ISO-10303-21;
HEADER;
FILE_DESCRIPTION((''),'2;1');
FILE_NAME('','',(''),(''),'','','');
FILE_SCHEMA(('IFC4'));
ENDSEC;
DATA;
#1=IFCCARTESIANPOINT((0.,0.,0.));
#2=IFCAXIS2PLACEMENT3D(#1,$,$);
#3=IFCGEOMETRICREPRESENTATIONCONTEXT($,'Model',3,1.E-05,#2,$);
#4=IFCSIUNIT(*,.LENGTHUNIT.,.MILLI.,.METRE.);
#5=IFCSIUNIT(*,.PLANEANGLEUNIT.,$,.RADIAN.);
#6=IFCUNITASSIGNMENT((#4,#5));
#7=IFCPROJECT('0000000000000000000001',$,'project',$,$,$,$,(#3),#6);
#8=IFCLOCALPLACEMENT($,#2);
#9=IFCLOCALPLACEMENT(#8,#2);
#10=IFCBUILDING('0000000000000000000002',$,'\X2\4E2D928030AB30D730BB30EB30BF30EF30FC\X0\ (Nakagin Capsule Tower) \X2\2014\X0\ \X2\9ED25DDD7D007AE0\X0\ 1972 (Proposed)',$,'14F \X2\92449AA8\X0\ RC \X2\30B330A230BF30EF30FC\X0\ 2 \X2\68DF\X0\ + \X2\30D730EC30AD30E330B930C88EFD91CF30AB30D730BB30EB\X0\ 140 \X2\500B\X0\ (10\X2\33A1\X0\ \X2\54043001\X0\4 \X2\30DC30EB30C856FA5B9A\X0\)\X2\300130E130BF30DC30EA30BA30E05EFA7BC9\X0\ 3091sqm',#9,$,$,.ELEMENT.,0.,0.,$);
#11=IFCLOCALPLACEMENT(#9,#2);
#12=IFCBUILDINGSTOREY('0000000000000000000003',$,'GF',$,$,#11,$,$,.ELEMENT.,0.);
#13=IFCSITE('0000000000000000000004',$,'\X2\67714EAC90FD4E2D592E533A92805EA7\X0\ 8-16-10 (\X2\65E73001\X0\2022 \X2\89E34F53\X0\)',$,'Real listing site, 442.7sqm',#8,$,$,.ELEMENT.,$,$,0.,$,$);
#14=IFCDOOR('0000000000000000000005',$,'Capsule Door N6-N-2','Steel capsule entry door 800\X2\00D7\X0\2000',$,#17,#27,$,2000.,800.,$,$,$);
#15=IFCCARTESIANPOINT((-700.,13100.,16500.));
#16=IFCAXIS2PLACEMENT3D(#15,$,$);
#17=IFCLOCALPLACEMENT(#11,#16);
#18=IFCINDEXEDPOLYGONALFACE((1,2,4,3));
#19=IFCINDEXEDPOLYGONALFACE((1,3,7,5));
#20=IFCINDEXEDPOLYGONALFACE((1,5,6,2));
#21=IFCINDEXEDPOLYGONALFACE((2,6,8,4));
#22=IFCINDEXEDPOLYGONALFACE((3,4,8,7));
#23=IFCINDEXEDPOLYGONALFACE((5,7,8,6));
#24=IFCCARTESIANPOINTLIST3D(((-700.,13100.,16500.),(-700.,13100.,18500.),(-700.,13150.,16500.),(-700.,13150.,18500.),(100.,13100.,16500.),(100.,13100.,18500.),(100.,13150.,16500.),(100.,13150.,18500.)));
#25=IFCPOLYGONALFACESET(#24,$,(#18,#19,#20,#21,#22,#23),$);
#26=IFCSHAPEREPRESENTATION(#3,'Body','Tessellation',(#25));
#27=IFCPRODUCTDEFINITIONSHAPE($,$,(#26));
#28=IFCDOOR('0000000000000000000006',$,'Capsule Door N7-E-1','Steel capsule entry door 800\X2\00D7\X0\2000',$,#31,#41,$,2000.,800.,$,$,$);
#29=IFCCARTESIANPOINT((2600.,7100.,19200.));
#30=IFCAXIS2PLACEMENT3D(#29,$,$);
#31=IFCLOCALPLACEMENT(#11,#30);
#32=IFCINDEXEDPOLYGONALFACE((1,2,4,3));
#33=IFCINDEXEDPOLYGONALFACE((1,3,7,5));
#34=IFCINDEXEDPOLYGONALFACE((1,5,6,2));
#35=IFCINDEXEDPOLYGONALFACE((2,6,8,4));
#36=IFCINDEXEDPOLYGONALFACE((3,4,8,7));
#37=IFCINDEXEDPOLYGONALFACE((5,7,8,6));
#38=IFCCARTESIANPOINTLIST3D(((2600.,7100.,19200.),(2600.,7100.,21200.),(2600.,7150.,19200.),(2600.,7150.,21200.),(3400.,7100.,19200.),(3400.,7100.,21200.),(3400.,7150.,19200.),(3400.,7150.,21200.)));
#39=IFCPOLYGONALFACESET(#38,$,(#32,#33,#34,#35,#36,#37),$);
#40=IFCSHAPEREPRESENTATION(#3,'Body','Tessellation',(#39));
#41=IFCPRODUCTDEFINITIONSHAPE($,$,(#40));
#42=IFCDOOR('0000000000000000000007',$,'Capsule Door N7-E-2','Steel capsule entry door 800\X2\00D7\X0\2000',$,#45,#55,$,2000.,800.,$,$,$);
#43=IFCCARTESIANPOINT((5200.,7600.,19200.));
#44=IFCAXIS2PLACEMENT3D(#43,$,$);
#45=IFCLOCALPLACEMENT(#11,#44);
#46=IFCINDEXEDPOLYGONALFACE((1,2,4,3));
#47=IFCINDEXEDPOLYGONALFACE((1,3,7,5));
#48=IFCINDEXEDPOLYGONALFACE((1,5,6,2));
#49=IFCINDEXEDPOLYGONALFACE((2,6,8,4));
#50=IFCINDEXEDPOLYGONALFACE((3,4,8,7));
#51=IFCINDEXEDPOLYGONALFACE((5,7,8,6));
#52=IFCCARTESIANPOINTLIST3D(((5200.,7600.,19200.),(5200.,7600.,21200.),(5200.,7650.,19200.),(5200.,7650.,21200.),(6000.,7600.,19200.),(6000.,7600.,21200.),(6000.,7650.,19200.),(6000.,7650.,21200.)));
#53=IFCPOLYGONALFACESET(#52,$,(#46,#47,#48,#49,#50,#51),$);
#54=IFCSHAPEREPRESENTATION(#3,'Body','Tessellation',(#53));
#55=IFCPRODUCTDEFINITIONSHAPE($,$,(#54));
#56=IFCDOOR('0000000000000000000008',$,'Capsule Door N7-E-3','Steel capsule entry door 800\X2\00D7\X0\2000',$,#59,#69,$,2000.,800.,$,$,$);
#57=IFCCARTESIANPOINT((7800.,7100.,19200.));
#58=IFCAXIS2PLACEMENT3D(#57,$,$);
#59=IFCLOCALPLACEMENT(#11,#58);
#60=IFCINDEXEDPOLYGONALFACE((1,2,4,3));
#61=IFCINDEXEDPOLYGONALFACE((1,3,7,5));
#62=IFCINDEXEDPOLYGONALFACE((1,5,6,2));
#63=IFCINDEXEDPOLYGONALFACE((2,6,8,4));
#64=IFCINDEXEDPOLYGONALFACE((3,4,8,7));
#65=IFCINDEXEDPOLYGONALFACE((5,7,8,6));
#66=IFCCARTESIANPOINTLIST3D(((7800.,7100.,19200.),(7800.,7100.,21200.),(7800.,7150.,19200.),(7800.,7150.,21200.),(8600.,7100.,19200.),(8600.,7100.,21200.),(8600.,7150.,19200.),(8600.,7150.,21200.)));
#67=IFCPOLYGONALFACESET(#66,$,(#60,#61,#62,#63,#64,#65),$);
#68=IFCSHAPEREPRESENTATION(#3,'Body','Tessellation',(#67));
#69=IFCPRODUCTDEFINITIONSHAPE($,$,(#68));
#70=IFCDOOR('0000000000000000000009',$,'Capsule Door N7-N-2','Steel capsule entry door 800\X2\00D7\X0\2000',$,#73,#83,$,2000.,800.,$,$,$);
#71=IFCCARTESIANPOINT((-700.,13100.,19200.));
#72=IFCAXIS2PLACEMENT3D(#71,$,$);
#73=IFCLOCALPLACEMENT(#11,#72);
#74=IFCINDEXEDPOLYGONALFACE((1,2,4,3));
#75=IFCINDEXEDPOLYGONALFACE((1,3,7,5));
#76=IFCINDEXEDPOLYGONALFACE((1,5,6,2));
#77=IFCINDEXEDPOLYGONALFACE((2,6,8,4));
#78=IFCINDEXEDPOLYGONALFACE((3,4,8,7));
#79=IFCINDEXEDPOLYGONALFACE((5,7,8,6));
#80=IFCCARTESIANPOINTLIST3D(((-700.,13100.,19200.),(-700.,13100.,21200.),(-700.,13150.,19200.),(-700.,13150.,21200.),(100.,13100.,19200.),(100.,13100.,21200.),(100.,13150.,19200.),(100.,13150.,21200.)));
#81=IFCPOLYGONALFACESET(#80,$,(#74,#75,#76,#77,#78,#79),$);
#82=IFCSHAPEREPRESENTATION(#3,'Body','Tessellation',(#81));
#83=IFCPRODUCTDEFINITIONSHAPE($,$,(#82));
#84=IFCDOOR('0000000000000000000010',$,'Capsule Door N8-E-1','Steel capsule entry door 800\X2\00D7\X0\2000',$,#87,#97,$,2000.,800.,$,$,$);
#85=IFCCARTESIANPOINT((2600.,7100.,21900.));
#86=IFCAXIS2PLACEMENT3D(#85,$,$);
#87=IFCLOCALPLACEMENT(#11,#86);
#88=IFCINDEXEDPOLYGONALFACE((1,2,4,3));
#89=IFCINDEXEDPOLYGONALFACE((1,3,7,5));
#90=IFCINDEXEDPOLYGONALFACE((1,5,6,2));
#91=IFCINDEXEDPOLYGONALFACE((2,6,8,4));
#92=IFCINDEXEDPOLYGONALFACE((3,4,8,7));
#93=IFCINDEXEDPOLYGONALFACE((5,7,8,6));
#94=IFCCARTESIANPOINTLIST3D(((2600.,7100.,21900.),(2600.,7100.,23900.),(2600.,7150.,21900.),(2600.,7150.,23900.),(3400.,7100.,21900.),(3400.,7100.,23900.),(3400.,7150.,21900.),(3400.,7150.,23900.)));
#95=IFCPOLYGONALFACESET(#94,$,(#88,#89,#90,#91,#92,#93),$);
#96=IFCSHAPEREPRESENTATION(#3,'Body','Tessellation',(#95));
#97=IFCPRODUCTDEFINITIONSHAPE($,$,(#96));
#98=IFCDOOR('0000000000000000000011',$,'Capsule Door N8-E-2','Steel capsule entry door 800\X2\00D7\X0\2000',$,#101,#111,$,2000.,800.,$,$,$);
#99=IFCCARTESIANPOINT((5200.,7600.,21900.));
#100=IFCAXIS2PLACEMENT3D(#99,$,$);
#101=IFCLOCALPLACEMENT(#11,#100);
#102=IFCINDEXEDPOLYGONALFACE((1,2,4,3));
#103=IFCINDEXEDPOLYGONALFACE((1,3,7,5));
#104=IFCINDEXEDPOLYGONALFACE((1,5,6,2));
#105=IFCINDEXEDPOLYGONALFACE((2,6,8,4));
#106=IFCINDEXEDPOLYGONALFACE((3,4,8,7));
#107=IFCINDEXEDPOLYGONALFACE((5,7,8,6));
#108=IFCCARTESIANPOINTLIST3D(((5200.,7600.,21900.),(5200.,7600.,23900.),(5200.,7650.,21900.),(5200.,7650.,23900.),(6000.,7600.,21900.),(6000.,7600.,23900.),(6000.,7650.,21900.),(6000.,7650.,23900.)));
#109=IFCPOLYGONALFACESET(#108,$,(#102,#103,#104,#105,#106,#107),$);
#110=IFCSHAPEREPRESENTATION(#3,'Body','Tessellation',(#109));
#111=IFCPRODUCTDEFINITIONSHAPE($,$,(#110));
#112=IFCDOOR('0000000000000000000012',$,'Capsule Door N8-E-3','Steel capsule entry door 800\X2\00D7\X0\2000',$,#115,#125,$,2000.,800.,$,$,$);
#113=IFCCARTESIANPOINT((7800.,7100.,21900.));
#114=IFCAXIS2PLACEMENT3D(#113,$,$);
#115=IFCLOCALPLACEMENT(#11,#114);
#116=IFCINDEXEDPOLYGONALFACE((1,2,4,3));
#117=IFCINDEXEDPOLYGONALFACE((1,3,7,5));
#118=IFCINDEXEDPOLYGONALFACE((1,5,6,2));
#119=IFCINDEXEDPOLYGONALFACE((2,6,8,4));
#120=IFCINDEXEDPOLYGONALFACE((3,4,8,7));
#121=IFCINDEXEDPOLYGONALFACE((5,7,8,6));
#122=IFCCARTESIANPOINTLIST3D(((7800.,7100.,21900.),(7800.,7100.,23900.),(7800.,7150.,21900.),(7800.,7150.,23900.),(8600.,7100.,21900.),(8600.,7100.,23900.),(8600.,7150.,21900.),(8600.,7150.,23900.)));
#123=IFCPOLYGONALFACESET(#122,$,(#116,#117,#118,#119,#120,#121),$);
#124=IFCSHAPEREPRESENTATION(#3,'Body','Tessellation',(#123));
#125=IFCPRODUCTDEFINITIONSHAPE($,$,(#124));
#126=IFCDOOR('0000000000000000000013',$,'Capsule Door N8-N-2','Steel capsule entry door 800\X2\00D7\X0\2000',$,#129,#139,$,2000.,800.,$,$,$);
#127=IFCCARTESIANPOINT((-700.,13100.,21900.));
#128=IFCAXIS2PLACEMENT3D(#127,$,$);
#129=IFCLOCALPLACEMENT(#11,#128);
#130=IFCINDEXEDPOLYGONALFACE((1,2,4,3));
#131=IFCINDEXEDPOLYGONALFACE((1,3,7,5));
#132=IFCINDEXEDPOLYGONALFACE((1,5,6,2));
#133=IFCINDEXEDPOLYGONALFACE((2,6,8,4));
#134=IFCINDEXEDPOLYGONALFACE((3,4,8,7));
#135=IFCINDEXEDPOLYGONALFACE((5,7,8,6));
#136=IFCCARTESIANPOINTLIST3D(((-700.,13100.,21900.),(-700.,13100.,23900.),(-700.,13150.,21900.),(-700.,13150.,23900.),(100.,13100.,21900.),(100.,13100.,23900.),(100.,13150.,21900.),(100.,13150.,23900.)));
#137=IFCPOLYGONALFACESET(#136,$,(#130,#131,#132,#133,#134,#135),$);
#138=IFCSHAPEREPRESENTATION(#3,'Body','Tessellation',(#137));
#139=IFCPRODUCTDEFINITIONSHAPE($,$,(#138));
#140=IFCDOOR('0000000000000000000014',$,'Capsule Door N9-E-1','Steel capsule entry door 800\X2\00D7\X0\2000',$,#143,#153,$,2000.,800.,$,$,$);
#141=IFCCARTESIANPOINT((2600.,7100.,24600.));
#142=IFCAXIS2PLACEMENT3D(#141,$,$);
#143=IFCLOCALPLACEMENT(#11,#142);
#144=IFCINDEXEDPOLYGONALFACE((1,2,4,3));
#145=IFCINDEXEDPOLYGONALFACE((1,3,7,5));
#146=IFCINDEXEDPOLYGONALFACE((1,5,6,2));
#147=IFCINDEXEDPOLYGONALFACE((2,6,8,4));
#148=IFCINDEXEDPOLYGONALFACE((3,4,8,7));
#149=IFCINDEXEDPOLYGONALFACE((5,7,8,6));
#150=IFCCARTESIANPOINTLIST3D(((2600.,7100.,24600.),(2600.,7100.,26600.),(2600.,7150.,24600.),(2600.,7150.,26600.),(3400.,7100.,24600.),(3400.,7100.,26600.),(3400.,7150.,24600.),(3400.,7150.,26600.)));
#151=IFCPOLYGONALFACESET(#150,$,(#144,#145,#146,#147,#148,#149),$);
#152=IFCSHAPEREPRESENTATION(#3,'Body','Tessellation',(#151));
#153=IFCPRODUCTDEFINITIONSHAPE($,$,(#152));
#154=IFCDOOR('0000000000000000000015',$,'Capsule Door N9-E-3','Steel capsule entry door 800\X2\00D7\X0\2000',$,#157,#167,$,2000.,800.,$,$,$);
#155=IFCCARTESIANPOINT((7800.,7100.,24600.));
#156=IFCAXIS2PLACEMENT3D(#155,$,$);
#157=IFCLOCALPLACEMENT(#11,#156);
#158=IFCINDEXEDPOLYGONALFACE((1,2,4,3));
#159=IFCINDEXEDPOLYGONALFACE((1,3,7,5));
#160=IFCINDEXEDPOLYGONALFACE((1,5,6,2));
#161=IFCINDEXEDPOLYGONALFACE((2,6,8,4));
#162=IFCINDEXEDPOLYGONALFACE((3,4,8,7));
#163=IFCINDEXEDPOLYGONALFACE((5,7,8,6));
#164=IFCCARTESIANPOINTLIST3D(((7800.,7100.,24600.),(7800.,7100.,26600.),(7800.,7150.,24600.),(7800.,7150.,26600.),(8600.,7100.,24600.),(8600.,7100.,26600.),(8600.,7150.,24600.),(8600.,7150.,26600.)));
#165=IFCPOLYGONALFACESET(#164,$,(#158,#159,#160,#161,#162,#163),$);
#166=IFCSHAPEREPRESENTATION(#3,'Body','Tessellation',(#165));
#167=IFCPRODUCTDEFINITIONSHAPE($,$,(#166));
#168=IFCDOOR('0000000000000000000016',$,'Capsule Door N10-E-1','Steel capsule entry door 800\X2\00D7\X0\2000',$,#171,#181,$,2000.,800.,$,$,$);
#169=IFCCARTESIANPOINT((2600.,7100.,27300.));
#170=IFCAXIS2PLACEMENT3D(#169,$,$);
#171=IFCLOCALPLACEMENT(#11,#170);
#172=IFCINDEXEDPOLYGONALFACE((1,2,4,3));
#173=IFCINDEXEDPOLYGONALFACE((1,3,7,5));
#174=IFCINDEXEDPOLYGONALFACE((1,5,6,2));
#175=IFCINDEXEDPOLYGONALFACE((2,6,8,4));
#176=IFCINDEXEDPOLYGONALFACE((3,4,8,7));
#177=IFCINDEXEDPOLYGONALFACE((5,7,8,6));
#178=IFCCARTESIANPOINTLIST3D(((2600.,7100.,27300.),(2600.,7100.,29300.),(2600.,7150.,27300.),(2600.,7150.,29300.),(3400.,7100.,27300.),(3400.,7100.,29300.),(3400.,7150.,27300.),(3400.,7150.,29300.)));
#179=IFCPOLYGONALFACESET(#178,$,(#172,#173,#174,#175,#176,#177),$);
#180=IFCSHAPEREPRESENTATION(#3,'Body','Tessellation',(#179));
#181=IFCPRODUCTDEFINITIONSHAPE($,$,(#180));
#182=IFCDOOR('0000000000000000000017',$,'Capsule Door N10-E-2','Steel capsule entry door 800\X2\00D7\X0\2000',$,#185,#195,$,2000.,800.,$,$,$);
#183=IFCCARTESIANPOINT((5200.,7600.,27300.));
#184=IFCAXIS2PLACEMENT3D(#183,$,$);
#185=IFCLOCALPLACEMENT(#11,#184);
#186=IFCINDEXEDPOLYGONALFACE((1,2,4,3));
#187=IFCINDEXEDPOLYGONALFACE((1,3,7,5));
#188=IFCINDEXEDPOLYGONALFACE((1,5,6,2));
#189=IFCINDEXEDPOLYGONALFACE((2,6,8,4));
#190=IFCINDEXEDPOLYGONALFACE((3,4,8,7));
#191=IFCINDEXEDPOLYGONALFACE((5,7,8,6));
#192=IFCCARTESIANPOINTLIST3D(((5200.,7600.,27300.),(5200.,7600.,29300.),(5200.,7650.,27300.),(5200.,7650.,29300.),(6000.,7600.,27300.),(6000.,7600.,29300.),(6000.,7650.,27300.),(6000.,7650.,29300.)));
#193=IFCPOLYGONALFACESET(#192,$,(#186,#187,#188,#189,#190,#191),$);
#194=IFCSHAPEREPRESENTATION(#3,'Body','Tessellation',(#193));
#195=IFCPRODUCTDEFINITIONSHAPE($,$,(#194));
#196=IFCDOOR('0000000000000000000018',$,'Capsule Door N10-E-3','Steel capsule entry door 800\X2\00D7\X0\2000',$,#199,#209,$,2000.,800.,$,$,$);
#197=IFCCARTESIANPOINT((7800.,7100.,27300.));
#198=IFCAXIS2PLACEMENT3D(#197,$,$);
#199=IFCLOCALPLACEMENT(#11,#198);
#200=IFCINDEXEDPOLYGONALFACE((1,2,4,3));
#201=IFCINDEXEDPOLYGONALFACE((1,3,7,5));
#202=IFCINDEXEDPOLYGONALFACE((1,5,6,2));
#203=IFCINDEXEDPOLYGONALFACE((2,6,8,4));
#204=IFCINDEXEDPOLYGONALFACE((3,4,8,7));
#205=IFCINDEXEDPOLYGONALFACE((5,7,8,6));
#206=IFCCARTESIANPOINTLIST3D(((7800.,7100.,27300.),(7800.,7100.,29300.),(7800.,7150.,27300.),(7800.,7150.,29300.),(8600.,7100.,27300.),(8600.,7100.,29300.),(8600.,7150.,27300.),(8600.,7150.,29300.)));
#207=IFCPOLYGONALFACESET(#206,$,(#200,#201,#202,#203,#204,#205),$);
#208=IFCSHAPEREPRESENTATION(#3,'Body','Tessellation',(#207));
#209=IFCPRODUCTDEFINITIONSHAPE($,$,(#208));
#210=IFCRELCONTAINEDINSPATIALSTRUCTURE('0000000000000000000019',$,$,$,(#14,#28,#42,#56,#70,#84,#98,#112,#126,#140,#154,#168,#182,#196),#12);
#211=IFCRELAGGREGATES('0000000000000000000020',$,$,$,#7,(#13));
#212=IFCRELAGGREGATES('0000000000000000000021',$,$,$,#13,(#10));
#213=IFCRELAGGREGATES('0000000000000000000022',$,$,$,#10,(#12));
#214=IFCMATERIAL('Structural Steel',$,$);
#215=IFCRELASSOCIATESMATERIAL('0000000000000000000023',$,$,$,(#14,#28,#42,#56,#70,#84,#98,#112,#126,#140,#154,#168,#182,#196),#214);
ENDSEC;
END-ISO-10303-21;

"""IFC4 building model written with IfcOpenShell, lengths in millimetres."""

from ifc_helpers import new_model, si_unit, frame, frame_2d, origin, place, context, project, spatial, rectangle, extrude, material, element, save


model = new_model("IFC4")

# Units and contexts
model_context = context("Model", 3, precision=1e-05, world=origin())
ifc_project = project(units=[si_unit("LENGTHUNIT", "METRE", prefix="MILLI"), si_unit("PLANEANGLEUNIT", "RADIAN")], contexts=[model_context])

# Site, building, storey
site_placement = place(None, origin())
site = spatial("IfcSite", under=ifc_project, at=site_placement, Name="東京都中央区銀座 8-16-10 (旧、2022 解体)", ObjectType="Real listing site, 442.7sqm", CompositionType="ELEMENT", RefElevation=0.0)
building_placement = place(site_placement, origin())
building = spatial("IfcBuilding", under=site, at=building_placement, Name="中銀カプセルタワー (Nakagin Capsule Tower) — 黒川紀章 1972 (Proposed)", ObjectType="14F 鉄骨 RC コアタワー 2 棟 + プレキャスト軽量カプセル 140 個 (10㎡ 各、4 ボルト固定)、メタボリズム建築 3091sqm", CompositionType="ELEMENT", ElevationOfRefHeight=0.0, ElevationOfTerrain=0.0)
storey_placement = place(building_placement, origin())
storey = spatial("IfcBuildingStorey", under=building, at=storey_placement, Name="GF", CompositionType="ELEMENT", Elevation=0.0)

# Doors
ifc_material_1 = material(Name="Structural Steel")
door_1_placement = place(storey_placement, frame((-700.0, 13100.0, 16500.0)))
element("IfcDoor", 1, at=door_1_placement, inside=storey, material=ifc_material_1, Name="Capsule Door N6-N-2", Description="Steel capsule entry door 800×2000", OverallHeight=2000.0, OverallWidth=800.0, context=model_context, shape_type="SweptSolid", body=[
    extrude(rectangle(XDim=800.0, YDim=50.0, at=frame_2d((400.0, 25.0))), frame((-700.0, 13100.0, 16500.0)), (0.0, 0.0, 1.0), 2000.0),
])
door_2_placement = place(storey_placement, frame((2600.0, 7100.0, 19200.0)))
element("IfcDoor", 2, at=door_2_placement, inside=storey, material=ifc_material_1, Name="Capsule Door N7-E-1", Description="Steel capsule entry door 800×2000", OverallHeight=2000.0, OverallWidth=800.0, context=model_context, shape_type="SweptSolid", body=[
    extrude(rectangle(XDim=800.0, YDim=50.0, at=frame_2d((400.0, 25.0))), frame((2600.0, 7100.0, 19200.0)), (0.0, 0.0, 1.0), 2000.0),
])
door_3_placement = place(storey_placement, frame((5200.0, 7600.0, 19200.0)))
element("IfcDoor", 3, at=door_3_placement, inside=storey, material=ifc_material_1, Name="Capsule Door N7-E-2", Description="Steel capsule entry door 800×2000", OverallHeight=2000.0, OverallWidth=800.0, context=model_context, shape_type="SweptSolid", body=[
    extrude(rectangle(XDim=800.0, YDim=50.0, at=frame_2d((400.0, 25.0))), frame((5200.0, 7600.0, 19200.0)), (0.0, 0.0, 1.0), 2000.0),
])
door_4_placement = place(storey_placement, frame((7800.0, 7100.0, 19200.0)))
element("IfcDoor", 4, at=door_4_placement, inside=storey, material=ifc_material_1, Name="Capsule Door N7-E-3", Description="Steel capsule entry door 800×2000", OverallHeight=2000.0, OverallWidth=800.0, context=model_context, shape_type="SweptSolid", body=[
    extrude(rectangle(XDim=800.0, YDim=50.0, at=frame_2d((400.0, 25.0))), frame((7800.0, 7100.0, 19200.0)), (0.0, 0.0, 1.0), 2000.0),
])
door_5_placement = place(storey_placement, frame((-700.0, 13100.0, 19200.0)))
element("IfcDoor", 5, at=door_5_placement, inside=storey, material=ifc_material_1, Name="Capsule Door N7-N-2", Description="Steel capsule entry door 800×2000", OverallHeight=2000.0, OverallWidth=800.0, context=model_context, shape_type="SweptSolid", body=[
    extrude(rectangle(XDim=800.0, YDim=50.0, at=frame_2d((400.0, 25.0))), frame((-700.0, 13100.0, 19200.0)), (0.0, 0.0, 1.0), 2000.0),
])
door_6_placement = place(storey_placement, frame((2600.0, 7100.0, 21900.0)))
element("IfcDoor", 6, at=door_6_placement, inside=storey, material=ifc_material_1, Name="Capsule Door N8-E-1", Description="Steel capsule entry door 800×2000", OverallHeight=2000.0, OverallWidth=800.0, context=model_context, shape_type="SweptSolid", body=[
    extrude(rectangle(XDim=800.0, YDim=50.0, at=frame_2d((400.0, 25.0))), frame((2600.0, 7100.0, 21900.0)), (0.0, 0.0, 1.0), 2000.0),
])
door_7_placement = place(storey_placement, frame((5200.0, 7600.0, 21900.0)))
element("IfcDoor", 7, at=door_7_placement, inside=storey, material=ifc_material_1, Name="Capsule Door N8-E-2", Description="Steel capsule entry door 800×2000", OverallHeight=2000.0, OverallWidth=800.0, context=model_context, shape_type="SweptSolid", body=[
    extrude(rectangle(XDim=800.0, YDim=50.0, at=frame_2d((400.0, 25.0))), frame((5200.0, 7600.0, 21900.0)), (0.0, 0.0, 1.0), 2000.0),
])
door_8_placement = place(storey_placement, frame((7800.0, 7100.0, 21900.0)))
element("IfcDoor", 8, at=door_8_placement, inside=storey, material=ifc_material_1, Name="Capsule Door N8-E-3", Description="Steel capsule entry door 800×2000", OverallHeight=2000.0, OverallWidth=800.0, context=model_context, shape_type="SweptSolid", body=[
    extrude(rectangle(XDim=800.0, YDim=50.0, at=frame_2d((400.0, 25.0))), frame((7800.0, 7100.0, 21900.0)), (0.0, 0.0, 1.0), 2000.0),
])
door_9_placement = place(storey_placement, frame((-700.0, 13100.0, 21900.0)))
element("IfcDoor", 9, at=door_9_placement, inside=storey, material=ifc_material_1, Name="Capsule Door N8-N-2", Description="Steel capsule entry door 800×2000", OverallHeight=2000.0, OverallWidth=800.0, context=model_context, shape_type="SweptSolid", body=[
    extrude(rectangle(XDim=800.0, YDim=50.0, at=frame_2d((400.0, 25.0))), frame((-700.0, 13100.0, 21900.0)), (0.0, 0.0, 1.0), 2000.0),
])
door_10_placement = place(storey_placement, frame((2600.0, 7100.0, 24600.0)))
element("IfcDoor", 10, at=door_10_placement, inside=storey, material=ifc_material_1, Name="Capsule Door N9-E-1", Description="Steel capsule entry door 800×2000", OverallHeight=2000.0, OverallWidth=800.0, context=model_context, shape_type="SweptSolid", body=[
    extrude(rectangle(XDim=800.0, YDim=50.0, at=frame_2d((400.0, 25.0))), frame((2600.0, 7100.0, 24600.0)), (0.0, 0.0, 1.0), 2000.0),
])
door_11_placement = place(storey_placement, frame((7800.0, 7100.0, 24600.0)))
element("IfcDoor", 11, at=door_11_placement, inside=storey, material=ifc_material_1, Name="Capsule Door N9-E-3", Description="Steel capsule entry door 800×2000", OverallHeight=2000.0, OverallWidth=800.0, context=model_context, shape_type="SweptSolid", body=[
    extrude(rectangle(XDim=800.0, YDim=50.0, at=frame_2d((400.0, 25.0))), frame((7800.0, 7100.0, 24600.0)), (0.0, 0.0, 1.0), 2000.0),
])
door_12_placement = place(storey_placement, frame((2600.0, 7100.0, 27300.0)))
element("IfcDoor", 12, at=door_12_placement, inside=storey, material=ifc_material_1, Name="Capsule Door N10-E-1", Description="Steel capsule entry door 800×2000", OverallHeight=2000.0, OverallWidth=800.0, context=model_context, shape_type="SweptSolid", body=[
    extrude(rectangle(XDim=800.0, YDim=50.0, at=frame_2d((400.0, 25.0))), frame((2600.0, 7100.0, 27300.0)), (0.0, 0.0, 1.0), 2000.0),
])
door_13_placement = place(storey_placement, frame((5200.0, 7600.0, 27300.0)))
element("IfcDoor", 13, at=door_13_placement, inside=storey, material=ifc_material_1, Name="Capsule Door N10-E-2", Description="Steel capsule entry door 800×2000", OverallHeight=2000.0, OverallWidth=800.0, context=model_context, shape_type="SweptSolid", body=[
    extrude(rectangle(XDim=800.0, YDim=50.0, at=frame_2d((400.0, 25.0))), frame((5200.0, 7600.0, 27300.0)), (0.0, 0.0, 1.0), 2000.0),
])
door_14_placement = place(storey_placement, frame((7800.0, 7100.0, 27300.0)))
element("IfcDoor", 14, at=door_14_placement, inside=storey, material=ifc_material_1, Name="Capsule Door N10-E-3", Description="Steel capsule entry door 800×2000", OverallHeight=2000.0, OverallWidth=800.0, context=model_context, shape_type="SweptSolid", body=[
    extrude(rectangle(XDim=800.0, YDim=50.0, at=frame_2d((400.0, 25.0))), frame((7800.0, 7100.0, 27300.0)), (0.0, 0.0, 1.0), 2000.0),
])

save(model, "model.ifc")
